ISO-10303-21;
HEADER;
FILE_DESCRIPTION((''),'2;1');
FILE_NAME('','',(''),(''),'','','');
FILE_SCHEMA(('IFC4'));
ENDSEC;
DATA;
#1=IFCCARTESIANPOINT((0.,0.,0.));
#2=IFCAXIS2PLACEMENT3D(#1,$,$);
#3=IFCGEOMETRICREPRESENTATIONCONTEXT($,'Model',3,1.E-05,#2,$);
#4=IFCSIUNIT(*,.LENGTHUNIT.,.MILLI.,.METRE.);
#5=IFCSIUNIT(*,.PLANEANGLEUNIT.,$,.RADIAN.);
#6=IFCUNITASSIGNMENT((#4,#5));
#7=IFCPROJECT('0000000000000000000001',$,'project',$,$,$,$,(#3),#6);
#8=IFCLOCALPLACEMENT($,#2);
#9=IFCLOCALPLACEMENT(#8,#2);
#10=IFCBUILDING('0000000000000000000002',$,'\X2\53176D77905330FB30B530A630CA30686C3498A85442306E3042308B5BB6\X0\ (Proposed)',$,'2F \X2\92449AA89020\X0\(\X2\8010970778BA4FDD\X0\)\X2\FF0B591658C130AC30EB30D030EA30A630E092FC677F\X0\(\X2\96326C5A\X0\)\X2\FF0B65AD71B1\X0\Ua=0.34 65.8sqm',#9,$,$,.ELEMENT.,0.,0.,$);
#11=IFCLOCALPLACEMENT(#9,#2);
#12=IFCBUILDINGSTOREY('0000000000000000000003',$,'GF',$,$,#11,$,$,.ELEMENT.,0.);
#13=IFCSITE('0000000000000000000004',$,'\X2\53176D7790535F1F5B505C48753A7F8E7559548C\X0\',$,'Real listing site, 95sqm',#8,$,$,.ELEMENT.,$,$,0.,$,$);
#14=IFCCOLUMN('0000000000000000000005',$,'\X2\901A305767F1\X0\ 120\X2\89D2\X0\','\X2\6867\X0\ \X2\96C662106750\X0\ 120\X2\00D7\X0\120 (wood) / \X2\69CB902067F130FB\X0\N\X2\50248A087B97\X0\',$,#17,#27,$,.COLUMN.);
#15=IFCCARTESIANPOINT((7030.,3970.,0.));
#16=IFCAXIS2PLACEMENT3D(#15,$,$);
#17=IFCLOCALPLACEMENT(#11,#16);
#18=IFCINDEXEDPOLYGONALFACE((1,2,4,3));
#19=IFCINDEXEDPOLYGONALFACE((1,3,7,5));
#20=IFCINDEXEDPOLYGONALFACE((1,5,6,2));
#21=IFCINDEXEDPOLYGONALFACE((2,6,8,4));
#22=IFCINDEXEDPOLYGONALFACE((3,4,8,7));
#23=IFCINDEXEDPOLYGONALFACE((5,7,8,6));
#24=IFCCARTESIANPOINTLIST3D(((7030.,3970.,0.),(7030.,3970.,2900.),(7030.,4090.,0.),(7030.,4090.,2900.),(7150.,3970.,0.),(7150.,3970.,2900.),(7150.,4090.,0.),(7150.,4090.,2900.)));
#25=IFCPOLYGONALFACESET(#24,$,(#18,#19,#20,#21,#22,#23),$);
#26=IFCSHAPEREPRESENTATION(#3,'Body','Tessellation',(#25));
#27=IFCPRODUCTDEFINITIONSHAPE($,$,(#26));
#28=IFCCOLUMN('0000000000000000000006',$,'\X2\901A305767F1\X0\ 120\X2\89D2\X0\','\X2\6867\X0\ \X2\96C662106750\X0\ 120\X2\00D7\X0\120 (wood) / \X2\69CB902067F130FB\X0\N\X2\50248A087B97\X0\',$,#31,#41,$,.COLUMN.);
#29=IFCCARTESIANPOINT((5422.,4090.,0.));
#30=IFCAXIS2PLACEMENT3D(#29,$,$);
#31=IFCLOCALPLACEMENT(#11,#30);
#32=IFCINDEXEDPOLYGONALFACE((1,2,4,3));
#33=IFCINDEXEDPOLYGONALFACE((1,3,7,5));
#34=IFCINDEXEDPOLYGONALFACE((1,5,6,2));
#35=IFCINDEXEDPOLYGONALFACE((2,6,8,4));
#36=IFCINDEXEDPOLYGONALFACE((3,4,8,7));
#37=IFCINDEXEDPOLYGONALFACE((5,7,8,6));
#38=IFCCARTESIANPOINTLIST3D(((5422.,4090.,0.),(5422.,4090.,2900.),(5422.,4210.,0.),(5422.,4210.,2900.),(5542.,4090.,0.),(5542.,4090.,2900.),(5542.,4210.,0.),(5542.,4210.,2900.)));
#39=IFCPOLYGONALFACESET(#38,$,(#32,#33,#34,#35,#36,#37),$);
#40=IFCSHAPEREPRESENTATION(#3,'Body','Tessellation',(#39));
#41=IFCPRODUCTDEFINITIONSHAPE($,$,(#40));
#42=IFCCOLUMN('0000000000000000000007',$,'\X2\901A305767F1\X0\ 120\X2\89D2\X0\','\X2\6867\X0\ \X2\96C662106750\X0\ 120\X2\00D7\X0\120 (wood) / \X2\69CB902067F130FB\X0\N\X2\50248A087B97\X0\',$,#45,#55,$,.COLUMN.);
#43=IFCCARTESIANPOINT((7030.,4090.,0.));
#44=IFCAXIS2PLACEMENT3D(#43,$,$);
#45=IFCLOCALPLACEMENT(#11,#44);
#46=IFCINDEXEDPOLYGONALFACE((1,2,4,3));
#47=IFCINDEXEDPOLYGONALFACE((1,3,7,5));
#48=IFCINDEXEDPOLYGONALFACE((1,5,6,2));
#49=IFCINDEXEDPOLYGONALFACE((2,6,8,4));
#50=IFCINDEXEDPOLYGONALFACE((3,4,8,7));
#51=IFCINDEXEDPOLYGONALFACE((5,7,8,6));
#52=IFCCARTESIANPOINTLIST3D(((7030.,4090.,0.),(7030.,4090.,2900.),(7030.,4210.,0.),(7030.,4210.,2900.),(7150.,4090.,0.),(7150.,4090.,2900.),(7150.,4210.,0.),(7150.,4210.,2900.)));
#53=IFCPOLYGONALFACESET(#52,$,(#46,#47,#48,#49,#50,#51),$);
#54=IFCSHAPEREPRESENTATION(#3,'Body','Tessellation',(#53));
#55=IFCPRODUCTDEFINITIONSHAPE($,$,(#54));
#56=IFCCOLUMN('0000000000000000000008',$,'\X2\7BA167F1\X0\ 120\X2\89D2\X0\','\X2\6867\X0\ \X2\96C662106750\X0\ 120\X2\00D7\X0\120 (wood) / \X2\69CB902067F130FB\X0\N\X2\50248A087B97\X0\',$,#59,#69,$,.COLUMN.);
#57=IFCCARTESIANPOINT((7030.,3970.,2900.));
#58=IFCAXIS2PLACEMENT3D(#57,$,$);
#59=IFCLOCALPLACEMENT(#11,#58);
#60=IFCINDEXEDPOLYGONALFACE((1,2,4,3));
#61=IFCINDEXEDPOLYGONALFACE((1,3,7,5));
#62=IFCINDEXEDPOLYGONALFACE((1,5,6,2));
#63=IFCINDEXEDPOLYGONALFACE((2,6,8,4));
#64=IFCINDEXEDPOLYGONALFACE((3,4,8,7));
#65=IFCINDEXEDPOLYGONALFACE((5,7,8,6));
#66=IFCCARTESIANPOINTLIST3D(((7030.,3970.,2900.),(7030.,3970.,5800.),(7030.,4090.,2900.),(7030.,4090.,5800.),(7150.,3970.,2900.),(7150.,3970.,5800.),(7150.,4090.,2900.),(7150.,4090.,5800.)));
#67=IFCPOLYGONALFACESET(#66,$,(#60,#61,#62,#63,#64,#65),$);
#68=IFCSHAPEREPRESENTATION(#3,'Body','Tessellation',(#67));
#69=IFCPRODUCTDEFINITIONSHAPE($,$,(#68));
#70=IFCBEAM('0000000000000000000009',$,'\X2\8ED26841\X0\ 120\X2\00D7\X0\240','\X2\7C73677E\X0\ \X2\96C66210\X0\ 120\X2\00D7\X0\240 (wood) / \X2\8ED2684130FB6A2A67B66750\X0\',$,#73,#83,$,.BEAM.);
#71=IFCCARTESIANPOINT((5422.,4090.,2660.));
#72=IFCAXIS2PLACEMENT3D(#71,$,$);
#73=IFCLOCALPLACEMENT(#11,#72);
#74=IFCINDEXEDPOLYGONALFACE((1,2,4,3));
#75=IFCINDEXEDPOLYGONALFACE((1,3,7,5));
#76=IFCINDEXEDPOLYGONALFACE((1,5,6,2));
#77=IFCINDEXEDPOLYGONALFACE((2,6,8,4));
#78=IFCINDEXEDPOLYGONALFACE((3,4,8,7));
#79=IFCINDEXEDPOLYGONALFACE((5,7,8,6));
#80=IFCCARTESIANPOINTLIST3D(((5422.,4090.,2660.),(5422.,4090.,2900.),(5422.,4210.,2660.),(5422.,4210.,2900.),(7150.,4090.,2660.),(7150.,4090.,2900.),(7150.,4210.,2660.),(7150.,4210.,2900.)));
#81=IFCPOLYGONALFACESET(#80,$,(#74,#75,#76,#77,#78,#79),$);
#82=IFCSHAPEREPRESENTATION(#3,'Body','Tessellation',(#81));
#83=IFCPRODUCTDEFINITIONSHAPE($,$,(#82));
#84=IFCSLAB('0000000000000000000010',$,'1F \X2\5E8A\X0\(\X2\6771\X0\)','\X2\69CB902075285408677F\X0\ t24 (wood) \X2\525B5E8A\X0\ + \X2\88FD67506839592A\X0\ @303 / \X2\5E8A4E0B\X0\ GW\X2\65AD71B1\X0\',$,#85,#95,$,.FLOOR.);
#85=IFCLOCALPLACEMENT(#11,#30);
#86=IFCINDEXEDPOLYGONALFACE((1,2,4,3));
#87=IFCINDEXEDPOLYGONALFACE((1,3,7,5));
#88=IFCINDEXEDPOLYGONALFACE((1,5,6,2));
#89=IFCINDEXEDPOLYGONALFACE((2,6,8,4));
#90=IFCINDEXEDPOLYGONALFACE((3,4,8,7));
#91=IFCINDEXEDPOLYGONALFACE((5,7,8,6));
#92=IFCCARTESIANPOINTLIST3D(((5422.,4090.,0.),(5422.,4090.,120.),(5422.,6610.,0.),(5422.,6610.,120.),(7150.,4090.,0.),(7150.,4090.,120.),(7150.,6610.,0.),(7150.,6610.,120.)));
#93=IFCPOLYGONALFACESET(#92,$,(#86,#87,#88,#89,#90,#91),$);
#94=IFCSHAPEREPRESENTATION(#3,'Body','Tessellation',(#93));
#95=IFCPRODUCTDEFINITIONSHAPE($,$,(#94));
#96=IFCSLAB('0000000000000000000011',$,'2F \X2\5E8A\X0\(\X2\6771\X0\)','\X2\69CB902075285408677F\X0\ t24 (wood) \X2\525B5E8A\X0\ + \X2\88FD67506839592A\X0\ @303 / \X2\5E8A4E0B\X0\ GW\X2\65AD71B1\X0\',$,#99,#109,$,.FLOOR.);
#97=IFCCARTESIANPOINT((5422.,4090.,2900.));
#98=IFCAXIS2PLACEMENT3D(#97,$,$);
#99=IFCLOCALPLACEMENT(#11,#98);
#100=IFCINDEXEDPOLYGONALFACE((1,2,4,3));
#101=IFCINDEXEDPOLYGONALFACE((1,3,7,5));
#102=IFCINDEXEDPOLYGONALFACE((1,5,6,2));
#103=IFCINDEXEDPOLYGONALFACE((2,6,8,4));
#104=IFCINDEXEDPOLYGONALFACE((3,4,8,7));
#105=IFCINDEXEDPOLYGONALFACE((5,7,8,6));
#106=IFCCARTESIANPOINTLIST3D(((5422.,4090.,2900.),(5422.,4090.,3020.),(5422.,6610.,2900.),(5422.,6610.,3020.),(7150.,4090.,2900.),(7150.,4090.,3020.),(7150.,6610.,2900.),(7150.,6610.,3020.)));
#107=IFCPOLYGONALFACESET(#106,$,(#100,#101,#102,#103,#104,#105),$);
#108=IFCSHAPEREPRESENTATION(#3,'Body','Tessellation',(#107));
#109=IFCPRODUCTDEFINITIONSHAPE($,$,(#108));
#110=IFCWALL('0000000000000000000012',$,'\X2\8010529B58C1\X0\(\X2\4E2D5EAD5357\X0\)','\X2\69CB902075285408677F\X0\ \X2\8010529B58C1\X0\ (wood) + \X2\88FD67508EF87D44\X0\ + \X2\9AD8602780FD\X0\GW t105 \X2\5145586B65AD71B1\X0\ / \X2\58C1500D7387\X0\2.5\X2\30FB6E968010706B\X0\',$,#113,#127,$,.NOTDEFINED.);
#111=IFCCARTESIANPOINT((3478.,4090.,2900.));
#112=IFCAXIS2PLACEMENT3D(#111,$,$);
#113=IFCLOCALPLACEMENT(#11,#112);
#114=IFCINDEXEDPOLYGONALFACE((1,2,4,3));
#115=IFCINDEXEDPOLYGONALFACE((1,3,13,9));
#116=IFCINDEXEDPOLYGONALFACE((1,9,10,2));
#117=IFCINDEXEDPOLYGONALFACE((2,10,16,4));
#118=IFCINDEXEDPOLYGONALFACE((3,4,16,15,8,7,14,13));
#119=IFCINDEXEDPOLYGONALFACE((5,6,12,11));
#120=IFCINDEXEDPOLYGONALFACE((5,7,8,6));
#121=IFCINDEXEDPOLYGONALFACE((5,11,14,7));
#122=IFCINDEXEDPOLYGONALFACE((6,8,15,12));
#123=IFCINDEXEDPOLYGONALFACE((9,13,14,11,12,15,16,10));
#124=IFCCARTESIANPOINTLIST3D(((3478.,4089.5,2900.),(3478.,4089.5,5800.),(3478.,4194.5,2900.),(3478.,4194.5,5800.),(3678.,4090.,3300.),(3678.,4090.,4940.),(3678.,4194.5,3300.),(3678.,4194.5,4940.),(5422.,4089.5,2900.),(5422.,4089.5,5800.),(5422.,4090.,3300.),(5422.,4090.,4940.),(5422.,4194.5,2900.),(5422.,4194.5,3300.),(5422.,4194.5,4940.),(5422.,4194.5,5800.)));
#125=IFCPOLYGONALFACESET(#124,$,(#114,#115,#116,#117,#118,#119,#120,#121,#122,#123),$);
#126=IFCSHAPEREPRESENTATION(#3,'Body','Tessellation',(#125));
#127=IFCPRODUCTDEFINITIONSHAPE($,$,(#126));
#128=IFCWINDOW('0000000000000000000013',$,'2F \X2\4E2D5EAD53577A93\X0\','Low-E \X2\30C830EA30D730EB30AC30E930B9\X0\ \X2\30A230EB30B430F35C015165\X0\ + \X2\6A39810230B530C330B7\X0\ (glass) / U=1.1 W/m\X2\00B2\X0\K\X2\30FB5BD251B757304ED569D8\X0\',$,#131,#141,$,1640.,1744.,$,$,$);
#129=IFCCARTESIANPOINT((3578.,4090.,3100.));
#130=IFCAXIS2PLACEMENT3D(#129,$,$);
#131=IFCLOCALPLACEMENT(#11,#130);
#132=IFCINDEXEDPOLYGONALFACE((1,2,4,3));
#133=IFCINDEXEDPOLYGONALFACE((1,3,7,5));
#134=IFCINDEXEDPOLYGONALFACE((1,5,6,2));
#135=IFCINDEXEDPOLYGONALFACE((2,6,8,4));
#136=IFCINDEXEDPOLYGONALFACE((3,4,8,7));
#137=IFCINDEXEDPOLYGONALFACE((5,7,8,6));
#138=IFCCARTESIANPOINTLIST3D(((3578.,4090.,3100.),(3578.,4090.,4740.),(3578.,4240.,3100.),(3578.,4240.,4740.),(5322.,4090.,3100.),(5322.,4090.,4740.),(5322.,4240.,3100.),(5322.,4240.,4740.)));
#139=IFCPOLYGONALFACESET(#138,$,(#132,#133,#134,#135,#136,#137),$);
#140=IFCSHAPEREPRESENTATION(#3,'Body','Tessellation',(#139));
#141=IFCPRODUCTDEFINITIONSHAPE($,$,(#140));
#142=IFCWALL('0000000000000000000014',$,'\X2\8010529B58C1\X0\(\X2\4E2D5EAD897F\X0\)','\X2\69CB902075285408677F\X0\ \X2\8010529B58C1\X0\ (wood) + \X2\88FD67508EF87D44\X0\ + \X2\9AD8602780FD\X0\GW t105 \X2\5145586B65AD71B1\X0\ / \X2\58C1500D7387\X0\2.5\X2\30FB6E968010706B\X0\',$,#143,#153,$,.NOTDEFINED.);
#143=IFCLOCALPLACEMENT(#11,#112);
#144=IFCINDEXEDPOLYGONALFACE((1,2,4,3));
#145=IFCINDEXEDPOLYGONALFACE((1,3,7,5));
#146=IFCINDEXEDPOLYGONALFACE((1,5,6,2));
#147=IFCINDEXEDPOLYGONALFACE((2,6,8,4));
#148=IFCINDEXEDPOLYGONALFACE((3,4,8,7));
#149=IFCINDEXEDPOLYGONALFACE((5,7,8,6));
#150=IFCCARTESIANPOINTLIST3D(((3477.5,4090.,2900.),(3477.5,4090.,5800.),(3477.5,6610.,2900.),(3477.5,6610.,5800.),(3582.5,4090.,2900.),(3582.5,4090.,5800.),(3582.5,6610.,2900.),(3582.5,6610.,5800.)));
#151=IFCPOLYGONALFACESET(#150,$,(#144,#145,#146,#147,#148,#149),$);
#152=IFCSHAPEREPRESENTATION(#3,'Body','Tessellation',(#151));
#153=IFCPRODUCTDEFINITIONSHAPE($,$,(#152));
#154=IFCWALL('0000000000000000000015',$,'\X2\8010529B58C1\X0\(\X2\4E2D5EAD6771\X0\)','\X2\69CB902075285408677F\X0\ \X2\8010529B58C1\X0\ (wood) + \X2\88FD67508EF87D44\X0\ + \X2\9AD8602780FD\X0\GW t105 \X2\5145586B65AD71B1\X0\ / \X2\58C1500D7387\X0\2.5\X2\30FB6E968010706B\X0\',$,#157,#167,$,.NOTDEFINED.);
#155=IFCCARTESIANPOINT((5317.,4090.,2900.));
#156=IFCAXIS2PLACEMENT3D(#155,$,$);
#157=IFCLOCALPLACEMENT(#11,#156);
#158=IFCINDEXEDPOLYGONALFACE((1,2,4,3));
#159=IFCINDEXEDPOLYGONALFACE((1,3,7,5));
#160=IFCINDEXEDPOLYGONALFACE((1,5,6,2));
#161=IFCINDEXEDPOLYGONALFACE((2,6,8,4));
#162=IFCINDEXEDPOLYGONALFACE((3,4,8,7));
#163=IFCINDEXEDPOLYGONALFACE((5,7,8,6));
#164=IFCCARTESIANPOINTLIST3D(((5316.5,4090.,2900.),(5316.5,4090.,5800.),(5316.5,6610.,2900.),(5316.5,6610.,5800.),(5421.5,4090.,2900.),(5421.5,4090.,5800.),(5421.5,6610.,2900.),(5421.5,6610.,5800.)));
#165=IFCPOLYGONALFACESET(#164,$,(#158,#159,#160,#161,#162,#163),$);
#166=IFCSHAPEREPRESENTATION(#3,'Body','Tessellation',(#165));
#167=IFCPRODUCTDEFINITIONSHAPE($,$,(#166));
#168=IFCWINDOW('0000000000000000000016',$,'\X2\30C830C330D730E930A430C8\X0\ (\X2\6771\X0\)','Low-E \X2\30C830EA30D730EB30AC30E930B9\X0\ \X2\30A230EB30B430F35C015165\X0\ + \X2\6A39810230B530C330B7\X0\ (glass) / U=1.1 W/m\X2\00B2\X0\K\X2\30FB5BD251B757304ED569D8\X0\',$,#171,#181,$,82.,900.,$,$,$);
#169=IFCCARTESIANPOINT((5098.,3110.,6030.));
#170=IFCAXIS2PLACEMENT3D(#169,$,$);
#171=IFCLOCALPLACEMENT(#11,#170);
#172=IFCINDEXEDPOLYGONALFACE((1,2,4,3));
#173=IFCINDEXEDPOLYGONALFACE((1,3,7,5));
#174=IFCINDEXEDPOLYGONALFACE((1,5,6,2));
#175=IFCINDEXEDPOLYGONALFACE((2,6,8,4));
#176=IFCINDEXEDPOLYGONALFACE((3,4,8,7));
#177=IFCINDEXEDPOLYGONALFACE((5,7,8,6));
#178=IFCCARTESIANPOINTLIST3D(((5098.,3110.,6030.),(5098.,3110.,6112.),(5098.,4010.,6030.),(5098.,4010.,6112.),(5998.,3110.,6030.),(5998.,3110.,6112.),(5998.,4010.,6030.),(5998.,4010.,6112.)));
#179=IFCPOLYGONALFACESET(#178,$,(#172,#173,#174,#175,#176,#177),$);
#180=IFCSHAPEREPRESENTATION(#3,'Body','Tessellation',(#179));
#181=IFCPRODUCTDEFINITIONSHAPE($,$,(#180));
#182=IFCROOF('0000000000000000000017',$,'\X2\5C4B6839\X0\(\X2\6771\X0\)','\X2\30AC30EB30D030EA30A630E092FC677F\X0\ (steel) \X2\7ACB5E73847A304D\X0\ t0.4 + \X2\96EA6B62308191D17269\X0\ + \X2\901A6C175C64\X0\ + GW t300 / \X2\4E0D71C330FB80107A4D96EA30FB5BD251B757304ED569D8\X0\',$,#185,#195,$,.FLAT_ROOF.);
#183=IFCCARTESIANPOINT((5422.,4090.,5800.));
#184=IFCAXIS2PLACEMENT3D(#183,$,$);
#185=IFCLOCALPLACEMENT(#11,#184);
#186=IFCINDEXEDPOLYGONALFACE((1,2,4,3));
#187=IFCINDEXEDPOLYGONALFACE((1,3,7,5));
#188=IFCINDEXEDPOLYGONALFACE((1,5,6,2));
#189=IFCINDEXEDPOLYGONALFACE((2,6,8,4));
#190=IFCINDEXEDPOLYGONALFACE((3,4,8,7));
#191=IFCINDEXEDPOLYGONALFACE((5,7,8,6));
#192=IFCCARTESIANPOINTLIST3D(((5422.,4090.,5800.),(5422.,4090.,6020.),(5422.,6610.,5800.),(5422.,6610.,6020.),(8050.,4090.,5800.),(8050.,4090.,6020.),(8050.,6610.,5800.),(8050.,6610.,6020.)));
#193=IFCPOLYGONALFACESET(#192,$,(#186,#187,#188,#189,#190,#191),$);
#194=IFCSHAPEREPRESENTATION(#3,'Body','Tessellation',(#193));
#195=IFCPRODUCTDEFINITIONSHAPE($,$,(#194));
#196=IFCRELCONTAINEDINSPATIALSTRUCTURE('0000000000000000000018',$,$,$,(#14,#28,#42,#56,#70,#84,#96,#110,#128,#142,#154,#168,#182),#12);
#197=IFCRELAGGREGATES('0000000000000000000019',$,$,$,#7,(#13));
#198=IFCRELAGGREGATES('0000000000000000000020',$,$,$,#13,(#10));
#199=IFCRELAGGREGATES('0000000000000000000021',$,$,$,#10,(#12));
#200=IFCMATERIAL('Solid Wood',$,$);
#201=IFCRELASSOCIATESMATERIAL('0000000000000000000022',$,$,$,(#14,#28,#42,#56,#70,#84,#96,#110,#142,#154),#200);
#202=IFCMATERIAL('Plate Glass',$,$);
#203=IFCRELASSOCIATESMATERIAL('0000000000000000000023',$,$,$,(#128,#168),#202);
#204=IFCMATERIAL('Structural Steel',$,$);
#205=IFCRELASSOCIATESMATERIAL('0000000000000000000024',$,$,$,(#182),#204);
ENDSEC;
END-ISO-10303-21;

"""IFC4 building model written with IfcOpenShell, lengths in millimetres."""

from ifc_helpers import new_model, si_unit, frame, frame_2d, origin, place, context, project, spatial, rectangle, extrude, material, element, fill, save


model = new_model("IFC4")

# Units and contexts
model_context = context("Model", 3, precision=1e-05, world=origin())
ifc_project = project(units=[si_unit("LENGTHUNIT", "METRE", prefix="MILLI"), si_unit("PLANEANGLEUNIT", "RADIAN")], contexts=[model_context])

# Site, building, storey
site_placement = place(None, origin())
site = spatial("IfcSite", under=ifc_project, at=site_placement, Name="北海道弟子屈町美留和", ObjectType="Real listing site, 95sqm", CompositionType="ELEMENT", RefElevation=0.0)
building_placement = place(site_placement, origin())
building = spatial("IfcBuilding", under=site, at=building_placement, Name="北海道・サウナと水風呂のある家 (Proposed)", ObjectType="2F 鉄骨造(耐震確保)＋外壁ガルバリウム鋼板(防汚)＋断熱Ua=0.34 65.8sqm", CompositionType="ELEMENT", ElevationOfRefHeight=0.0, ElevationOfTerrain=0.0)
storey_placement = place(building_placement, origin())
storey = spatial("IfcBuildingStorey", under=building, at=storey_placement, Name="GF", CompositionType="ELEMENT", Elevation=0.0)

# Columns
ifc_material_1 = material(Name="Solid Wood")
column_1_placement = place(storey_placement, frame((7030.0, 3970.0, 0.0)))
element("IfcColumn", 1, at=column_1_placement, inside=storey, material=ifc_material_1, Name="通し柱 120角", Description="桧 集成材 120×120 (wood) / 構造柱・N値計算", PredefinedType="COLUMN", context=model_context, shape_type="SweptSolid", body=[
    extrude(rectangle(XDim=120.0, YDim=120.0, at=frame_2d((60.0, 60.0))), frame((7030.0, 3970.0, 0.0)), (0.0, 0.0, 1.0), 2900.0),
])
column_2_placement = place(storey_placement, frame((5422.0, 4090.0, 0.0)))
element("IfcColumn", 2, at=column_2_placement, inside=storey, material=ifc_material_1, Name="通し柱 120角", Description="桧 集成材 120×120 (wood) / 構造柱・N値計算", PredefinedType="COLUMN", context=model_context, shape_type="SweptSolid", body=[
    extrude(rectangle(XDim=120.0, YDim=120.0, at=frame_2d((60.0, 60.0))), frame((5422.0, 4090.0, 0.0)), (0.0, 0.0, 1.0), 2900.0),
])
column_3_placement = place(storey_placement, frame((7030.0, 4090.0, 0.0)))
element("IfcColumn", 3, at=column_3_placement, inside=storey, material=ifc_material_1, Name="通し柱 120角", Description="桧 集成材 120×120 (wood) / 構造柱・N値計算", PredefinedType="COLUMN", context=model_context, shape_type="SweptSolid", body=[
    extrude(rectangle(XDim=120.0, YDim=120.0, at=frame_2d((60.0, 60.0))), frame((7030.0, 4090.0, 0.0)), (0.0, 0.0, 1.0), 2900.0),
])
column_4_placement = place(storey_placement, frame((7030.0, 3970.0, 2900.0)))
element("IfcColumn", 4, at=column_4_placement, inside=storey, material=ifc_material_1, Name="管柱 120角", Description="桧 集成材 120×120 (wood) / 構造柱・N値計算", PredefinedType="COLUMN", context=model_context, shape_type="SweptSolid", body=[
    extrude(rectangle(XDim=120.0, YDim=120.0, at=frame_2d((60.0, 60.0))), frame((7030.0, 3970.0, 2900.0)), (0.0, 0.0, 1.0), 2900.0),
])

# Beam
beam_1_placement = place(storey_placement, frame((5422.0, 4090.0, 2660.0)))
element("IfcBeam", 5, at=beam_1_placement, inside=storey, material=ifc_material_1, Name="軒桁 120×240", Description="米松 集成 120×240 (wood) / 軒桁・横架材", PredefinedType="BEAM", context=model_context, shape_type="SweptSolid", body=[
    extrude(rectangle(XDim=1728.0, YDim=120.0, at=frame_2d((864.0, 60.0))), frame((5422.0, 4090.0, 2660.0)), (0.0, 0.0, 1.0), 240.0),
])

# Slabs
slab_1_placement = place(storey_placement, frame((5422.0, 4090.0, 0.0)))
element("IfcSlab", 6, at=slab_1_placement, inside=storey, material=ifc_material_1, Name="1F 床(東)", Description="構造用合板 t24 (wood) 剛床 + 製材根太 @303 / 床下 GW断熱", PredefinedType="FLOOR", context=model_context, shape_type="SweptSolid", body=[
    extrude(rectangle(XDim=1728.0, YDim=2520.0, at=frame_2d((864.0, 1260.0))), frame((5422.0, 4090.0, 0.0)), (0.0, 0.0, 1.0), 120.0),
])
slab_2_placement = place(storey_placement, frame((5422.0, 4090.0, 2900.0)))
element("IfcSlab", 7, at=slab_2_placement, inside=storey, material=ifc_material_1, Name="2F 床(東)", Description="構造用合板 t24 (wood) 剛床 + 製材根太 @303 / 床下 GW断熱", PredefinedType="FLOOR", context=model_context, shape_type="SweptSolid", body=[
    extrude(rectangle(XDim=1728.0, YDim=2520.0, at=frame_2d((864.0, 1260.0))), frame((5422.0, 4090.0, 2900.0)), (0.0, 0.0, 1.0), 120.0),
])

# Wall, opening, window
wall_1_placement = place(storey_placement, frame((3478.0, 4090.0, 2900.0)))
wall_1 = element("IfcWall", 8, at=wall_1_placement, inside=storey, material=ifc_material_1, Name="耐力壁(中庭南)", Description="構造用合板 耐力壁 (wood) + 製材軸組 + 高性能GW t105 充填断熱 / 壁倍率2.5・準耐火", PredefinedType="NOTDEFINED", context=model_context, shape_type="SweptSolid", body=[
    extrude(rectangle(XDim=1944.0, YDim=105.0, at=frame_2d((972.0, 52.0))), frame((3478.0, 4090.0, 2900.0)), (0.0, 0.0, 1.0), 2900.0),
])
opening_placement = place(storey_placement, frame((3578.0, 4090.0, 3100.0)))
opening = element("IfcOpeningElement", 9, at=opening_placement, cuts=wall_1, PredefinedType="NOTDEFINED", context=model_context, shape_type="SweptSolid", body=[
    extrude(rectangle(XDim=1744.0, YDim=150.0, at=frame_2d((872.0, 75.0))), frame((3578.0, 4090.0, 3100.0)), (0.0, 0.0, 1.0), 1640.0),
])
ifc_material_2 = material(Name="Plate Glass")
window_1_placement = place(storey_placement, frame((3578.0, 4090.0, 3100.0)))
window_1 = element("IfcWindow", 10, at=window_1_placement, inside=storey, material=ifc_material_2, Name="2F 中庭南窓", Description="Low-E トリプルガラス アルゴン封入 + 樹脂サッシ (glass) / U=1.1 W/m²K・寒冷地仕様", OverallHeight=1640.0, OverallWidth=1744.0, context=model_context, shape_type="SweptSolid", body=[
    extrude(rectangle(XDim=1744.0, YDim=150.0, at=frame_2d((872.0, 75.0))), frame((3578.0, 4090.0, 3100.0)), (0.0, 0.0, 1.0), 1640.0),
])
fill(opening, window_1)

# Walls
wall_2_placement = place(storey_placement, frame((3478.0, 4090.0, 2900.0)))
element("IfcWall", 11, at=wall_2_placement, inside=storey, material=ifc_material_1, Name="耐力壁(中庭西)", Description="構造用合板 耐力壁 (wood) + 製材軸組 + 高性能GW t105 充填断熱 / 壁倍率2.5・準耐火", PredefinedType="NOTDEFINED", context=model_context, shape_type="SweptSolid", body=[
    extrude(rectangle(XDim=105.0, YDim=2520.0, at=frame_2d((52.0, 1260.0))), frame((3478.0, 4090.0, 2900.0)), (0.0, 0.0, 1.0), 2900.0),
])
wall_3_placement = place(storey_placement, frame((5317.0, 4090.0, 2900.0)))
element("IfcWall", 12, at=wall_3_placement, inside=storey, material=ifc_material_1, Name="耐力壁(中庭東)", Description="構造用合板 耐力壁 (wood) + 製材軸組 + 高性能GW t105 充填断熱 / 壁倍率2.5・準耐火", PredefinedType="NOTDEFINED", context=model_context, shape_type="SweptSolid", body=[
    extrude(rectangle(XDim=105.0, YDim=2520.0, at=frame_2d((52.0, 1260.0))), frame((5317.0, 4090.0, 2900.0)), (0.0, 0.0, 1.0), 2900.0),
])

# Window
window_2_placement = place(storey_placement, frame((5098.0, 3110.0, 6030.0)))
element("IfcWindow", 13, at=window_2_placement, inside=storey, material=ifc_material_2, Name="トップライト (東)", Description="Low-E トリプルガラス アルゴン封入 + 樹脂サッシ (glass) / U=1.1 W/m²K・寒冷地仕様", OverallHeight=82.0, OverallWidth=900.0, context=model_context, shape_type="SweptSolid", body=[
    extrude(rectangle(XDim=900.0, YDim=900.0, at=frame_2d((450.0, 450.0))), frame((5098.0, 3110.0, 6030.0)), (0.0, 0.0, 1.0), 82.0),
])

# Roof
ifc_material_3 = material(Name="Structural Steel")
for number, where, name in (
    (14, (5422.0, 4090.0, 5800.0), "屋根(東)"),
):
    element("IfcRoof", number, at=place(storey_placement, frame(where)), inside=storey, material=ifc_material_3, Name=name, Description="ガルバリウム鋼板 (steel) 立平葺き t0.4 + 雪止め金物 + 通気層 + GW t300 / 不燃・耐積雪・寒冷地仕様", PredefinedType="FLAT_ROOF", context=model_context, shape_type="SweptSolid", body=[
        extrude(rectangle(XDim=2628.0, YDim=2520.0, at=frame_2d((1314.0, 1260.0))), frame((5422.0, 4090.0, 5800.0)), (0.0, 0.0, 1.0), 220.0),
    ])

save(model, "model.ifc")
